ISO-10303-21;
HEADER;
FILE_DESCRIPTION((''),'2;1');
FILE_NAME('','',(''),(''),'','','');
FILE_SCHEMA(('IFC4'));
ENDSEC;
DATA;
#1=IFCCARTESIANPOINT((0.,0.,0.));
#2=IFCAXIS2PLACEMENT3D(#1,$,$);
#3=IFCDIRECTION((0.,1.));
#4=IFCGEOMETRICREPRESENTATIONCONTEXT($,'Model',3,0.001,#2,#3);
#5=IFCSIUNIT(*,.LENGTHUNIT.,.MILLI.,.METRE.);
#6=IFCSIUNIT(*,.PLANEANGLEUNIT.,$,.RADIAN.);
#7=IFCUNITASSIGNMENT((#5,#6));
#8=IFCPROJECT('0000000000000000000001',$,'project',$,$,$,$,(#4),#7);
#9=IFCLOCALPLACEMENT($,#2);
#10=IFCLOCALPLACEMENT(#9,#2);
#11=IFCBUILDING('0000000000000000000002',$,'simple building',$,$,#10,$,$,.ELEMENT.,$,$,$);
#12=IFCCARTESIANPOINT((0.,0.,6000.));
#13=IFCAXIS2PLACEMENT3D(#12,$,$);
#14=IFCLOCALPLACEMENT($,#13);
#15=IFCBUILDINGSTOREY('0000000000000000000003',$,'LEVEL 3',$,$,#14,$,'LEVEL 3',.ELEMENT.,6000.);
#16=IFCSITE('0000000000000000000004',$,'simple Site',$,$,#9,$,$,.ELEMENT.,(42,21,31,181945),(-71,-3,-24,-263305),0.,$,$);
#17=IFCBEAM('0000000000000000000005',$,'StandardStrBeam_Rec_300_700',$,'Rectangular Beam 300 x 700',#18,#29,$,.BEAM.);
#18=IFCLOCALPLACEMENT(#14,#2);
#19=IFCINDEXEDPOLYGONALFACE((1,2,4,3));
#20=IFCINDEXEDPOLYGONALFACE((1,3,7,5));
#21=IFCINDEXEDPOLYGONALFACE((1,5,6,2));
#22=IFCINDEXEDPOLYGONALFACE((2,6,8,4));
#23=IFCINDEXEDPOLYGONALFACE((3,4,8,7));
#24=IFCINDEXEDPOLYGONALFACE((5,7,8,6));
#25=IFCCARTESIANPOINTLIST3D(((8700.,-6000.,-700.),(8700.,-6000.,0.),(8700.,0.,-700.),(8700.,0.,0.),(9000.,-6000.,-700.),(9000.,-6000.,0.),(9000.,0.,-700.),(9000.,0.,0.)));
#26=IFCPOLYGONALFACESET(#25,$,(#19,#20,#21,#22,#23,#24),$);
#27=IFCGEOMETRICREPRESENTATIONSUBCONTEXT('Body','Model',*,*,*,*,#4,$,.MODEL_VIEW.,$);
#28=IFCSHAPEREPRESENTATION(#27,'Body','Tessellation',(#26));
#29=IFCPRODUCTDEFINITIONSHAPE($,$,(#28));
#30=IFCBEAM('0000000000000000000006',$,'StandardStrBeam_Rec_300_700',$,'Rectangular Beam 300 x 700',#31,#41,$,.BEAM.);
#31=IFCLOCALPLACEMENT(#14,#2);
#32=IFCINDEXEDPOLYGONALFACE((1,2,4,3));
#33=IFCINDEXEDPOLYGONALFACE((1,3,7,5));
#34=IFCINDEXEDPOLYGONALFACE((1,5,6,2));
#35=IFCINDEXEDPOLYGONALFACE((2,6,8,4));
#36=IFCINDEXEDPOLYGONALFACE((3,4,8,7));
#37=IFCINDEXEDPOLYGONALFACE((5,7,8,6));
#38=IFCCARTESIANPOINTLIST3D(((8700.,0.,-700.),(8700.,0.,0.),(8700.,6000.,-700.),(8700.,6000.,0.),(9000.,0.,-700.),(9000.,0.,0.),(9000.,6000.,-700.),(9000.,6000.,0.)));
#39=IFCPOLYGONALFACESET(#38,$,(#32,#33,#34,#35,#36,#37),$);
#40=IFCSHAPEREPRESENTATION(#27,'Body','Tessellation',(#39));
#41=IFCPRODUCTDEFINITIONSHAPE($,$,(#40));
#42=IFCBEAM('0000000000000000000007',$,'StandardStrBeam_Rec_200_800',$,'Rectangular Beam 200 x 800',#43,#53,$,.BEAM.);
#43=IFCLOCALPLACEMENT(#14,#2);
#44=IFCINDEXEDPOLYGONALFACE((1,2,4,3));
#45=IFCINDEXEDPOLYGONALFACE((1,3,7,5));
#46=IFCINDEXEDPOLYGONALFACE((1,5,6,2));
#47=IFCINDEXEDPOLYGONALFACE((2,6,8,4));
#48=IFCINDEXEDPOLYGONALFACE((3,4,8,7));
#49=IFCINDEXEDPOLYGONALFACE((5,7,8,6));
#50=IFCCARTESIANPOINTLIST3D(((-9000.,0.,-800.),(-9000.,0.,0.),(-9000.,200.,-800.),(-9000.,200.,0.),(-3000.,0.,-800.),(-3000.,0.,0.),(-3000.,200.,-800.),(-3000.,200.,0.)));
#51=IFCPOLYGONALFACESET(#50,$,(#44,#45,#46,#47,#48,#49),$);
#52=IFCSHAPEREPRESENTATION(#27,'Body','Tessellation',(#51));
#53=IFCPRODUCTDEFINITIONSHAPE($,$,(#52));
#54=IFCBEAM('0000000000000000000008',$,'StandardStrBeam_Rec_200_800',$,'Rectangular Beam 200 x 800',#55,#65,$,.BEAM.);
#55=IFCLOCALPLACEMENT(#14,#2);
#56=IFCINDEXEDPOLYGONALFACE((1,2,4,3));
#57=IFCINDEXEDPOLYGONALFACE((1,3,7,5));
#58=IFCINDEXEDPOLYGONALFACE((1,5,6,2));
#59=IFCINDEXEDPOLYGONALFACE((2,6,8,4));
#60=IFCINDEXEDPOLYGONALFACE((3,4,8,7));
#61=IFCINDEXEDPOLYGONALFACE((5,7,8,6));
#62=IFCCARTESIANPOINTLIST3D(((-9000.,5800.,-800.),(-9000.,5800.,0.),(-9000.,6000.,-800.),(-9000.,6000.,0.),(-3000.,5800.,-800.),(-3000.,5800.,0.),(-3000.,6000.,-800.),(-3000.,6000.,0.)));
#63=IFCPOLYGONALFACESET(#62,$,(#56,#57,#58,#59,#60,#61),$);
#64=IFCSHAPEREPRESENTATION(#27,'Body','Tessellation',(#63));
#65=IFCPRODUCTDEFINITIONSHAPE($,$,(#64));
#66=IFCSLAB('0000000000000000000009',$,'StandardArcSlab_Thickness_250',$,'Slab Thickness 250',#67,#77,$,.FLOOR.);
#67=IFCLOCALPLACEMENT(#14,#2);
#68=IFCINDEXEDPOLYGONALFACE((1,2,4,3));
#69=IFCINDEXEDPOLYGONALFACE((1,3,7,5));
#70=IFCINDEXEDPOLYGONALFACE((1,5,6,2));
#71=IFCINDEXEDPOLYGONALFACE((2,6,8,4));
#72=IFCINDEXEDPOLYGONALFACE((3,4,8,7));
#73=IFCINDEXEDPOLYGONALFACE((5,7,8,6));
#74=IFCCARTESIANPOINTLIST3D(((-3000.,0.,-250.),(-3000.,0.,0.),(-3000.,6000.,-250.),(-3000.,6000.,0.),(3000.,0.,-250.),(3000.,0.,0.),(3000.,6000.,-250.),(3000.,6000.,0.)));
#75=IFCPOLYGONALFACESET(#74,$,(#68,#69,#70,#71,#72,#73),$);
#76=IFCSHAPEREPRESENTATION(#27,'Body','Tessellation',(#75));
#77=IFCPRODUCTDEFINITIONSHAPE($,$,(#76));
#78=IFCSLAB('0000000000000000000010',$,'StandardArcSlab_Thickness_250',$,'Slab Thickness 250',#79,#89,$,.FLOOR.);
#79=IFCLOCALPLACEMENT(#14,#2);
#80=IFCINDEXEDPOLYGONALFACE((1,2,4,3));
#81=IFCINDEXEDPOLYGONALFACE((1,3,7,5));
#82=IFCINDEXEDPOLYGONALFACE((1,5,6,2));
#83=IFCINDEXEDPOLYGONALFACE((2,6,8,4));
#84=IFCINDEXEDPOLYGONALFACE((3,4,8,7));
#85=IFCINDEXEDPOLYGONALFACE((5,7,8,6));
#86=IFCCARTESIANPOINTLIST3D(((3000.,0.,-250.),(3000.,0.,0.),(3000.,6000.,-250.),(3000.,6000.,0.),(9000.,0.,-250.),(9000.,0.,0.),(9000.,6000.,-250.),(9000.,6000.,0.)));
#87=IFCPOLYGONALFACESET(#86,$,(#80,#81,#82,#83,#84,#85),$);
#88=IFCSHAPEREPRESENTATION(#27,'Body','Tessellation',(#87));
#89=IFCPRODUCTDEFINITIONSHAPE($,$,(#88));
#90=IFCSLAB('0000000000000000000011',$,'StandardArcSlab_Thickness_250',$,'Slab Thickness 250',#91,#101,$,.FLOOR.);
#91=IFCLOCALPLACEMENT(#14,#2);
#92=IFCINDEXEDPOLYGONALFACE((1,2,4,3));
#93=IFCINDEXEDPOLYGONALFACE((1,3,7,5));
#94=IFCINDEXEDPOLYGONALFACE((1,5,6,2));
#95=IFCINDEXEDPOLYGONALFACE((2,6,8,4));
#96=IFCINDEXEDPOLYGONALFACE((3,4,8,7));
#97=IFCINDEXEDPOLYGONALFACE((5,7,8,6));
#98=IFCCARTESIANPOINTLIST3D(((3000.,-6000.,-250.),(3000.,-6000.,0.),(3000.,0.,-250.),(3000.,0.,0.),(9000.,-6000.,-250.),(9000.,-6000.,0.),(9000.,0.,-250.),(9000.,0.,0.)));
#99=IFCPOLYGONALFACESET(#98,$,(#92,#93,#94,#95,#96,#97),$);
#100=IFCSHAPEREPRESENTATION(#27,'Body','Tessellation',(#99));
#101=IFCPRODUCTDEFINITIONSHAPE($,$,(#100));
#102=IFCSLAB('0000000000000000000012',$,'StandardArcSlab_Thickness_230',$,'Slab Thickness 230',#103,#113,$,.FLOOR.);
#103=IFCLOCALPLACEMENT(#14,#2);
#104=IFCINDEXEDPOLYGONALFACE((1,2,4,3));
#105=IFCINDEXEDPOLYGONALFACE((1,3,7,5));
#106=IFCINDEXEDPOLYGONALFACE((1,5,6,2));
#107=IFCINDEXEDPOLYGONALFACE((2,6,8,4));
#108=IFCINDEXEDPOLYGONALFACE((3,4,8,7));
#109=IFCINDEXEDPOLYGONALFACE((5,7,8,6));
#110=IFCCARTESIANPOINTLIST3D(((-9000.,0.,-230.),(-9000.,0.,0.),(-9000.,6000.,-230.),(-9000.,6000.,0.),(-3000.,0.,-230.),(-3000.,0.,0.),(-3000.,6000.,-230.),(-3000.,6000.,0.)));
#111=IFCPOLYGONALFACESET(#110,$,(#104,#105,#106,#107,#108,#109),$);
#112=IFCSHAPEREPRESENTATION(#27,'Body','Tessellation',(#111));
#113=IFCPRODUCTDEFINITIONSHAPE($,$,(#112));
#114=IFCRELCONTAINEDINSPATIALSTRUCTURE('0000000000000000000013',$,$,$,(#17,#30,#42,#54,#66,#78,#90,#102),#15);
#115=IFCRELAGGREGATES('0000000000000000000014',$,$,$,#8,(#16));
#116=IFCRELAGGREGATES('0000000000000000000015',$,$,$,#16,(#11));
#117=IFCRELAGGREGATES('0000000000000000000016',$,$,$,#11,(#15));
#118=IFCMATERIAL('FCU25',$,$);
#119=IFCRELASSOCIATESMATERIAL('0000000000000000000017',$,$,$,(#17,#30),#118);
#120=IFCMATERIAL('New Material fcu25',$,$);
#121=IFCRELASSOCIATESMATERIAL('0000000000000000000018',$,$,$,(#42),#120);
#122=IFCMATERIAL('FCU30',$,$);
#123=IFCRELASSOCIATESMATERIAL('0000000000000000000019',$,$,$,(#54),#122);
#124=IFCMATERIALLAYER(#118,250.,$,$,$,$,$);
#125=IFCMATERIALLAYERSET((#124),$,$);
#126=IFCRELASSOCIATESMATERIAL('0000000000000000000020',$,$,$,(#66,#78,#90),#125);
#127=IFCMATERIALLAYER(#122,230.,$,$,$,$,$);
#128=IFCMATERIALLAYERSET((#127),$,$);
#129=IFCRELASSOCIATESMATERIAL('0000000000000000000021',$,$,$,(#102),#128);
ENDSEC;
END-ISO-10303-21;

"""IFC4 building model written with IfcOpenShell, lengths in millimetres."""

from ifc_helpers import new_model, si_unit, direction, frame, origin, origin_with_axes, origin_2d_with_axis, place, context, subcontext, project, spatial, polyline, rectangle, outline, extrude, material, layer, layer_set, layer_usage, material_profile, profile_set, profile_usage, element, save


model = new_model("IFC4")

# Units and contexts
model_context = context("Model", 3, precision=0.001, world=origin(), true_north=direction((0.0, 1.0)))
body_context = subcontext(model_context, "Body", "Model", "MODEL_VIEW")
ifc_project = project(units=[si_unit("LENGTHUNIT", "METRE", prefix="MILLI"), si_unit("PLANEANGLEUNIT", "RADIAN")], contexts=[model_context])

# Site, building, storey
site_placement = place(None, origin())
site = spatial("IfcSite", under=ifc_project, at=site_placement, Name="simple Site", CompositionType="ELEMENT", RefLatitude=(42, 21, 31, 181945), RefLongitude=(-71, -3, -24, -263305), RefElevation=0.0)
building_placement = place(site_placement, origin())
building = spatial("IfcBuilding", under=site, at=building_placement, Name="simple building", CompositionType="ELEMENT")
storey_placement = place(None, frame((0.0, 0.0, 6000.0)))
storey = spatial("IfcBuildingStorey", under=building, at=storey_placement, Name="LEVEL 3", LongName="LEVEL 3", CompositionType="ELEMENT", Elevation=6000.0)

# Shared definitions
ifc_material_1 = material(Name="FCU30")

# Beams
ifc_material_2 = material(Name="FCU25")
ifc_material_profile_1 = material_profile(ifc_material_2, rectangle(XDim=300.0, YDim=700.0, at=origin_2d_with_axis()))
ifc_profile_set_1 = profile_set([ifc_material_profile_1])
ifc_profile_usage_1 = profile_usage(ifc_profile_set_1, cardinal=9)
for number, where, z_axis, x_axis, name in (
    (1, (8850.0, -6000.0, 5650.0), (0.0, 1.0, 0.0), (1.0, 0.0, 0.0), "StandardStrBeam_Rec_300_700"),
    (2, (8850.0, 0.0, 5650.0), (0.0, 1.0, 0.0), (1.0, 0.0, 0.0), "StandardStrBeam_Rec_300_700"),
):
    element("IfcBeam", number, at=place(None, frame(where, z_axis=z_axis, x_axis=x_axis)), inside=storey, material=ifc_profile_usage_1, Name=name, ObjectType="Rectangular Beam 300 x 700", PredefinedType="BEAM", context=body_context, shape_type="SweptSolid", body=[
        extrude(rectangle(XDim=300.0, YDim=700.0, at=origin_2d_with_axis()), origin_with_axes(), (0.0, 0.0, 1.0), 6000.0),
    ])
ifc_material_3 = material(Name="New Material fcu25")
ifc_material_profile_2 = material_profile(ifc_material_3, rectangle(XDim=200.0, YDim=800.0, at=origin_2d_with_axis()))
ifc_profile_set_2 = profile_set([ifc_material_profile_2])
ifc_profile_usage_2 = profile_usage(ifc_profile_set_2, cardinal=9)
beam_1_placement = place(None, frame((-9000.0, 100.0, 5600.0), z_axis=(1.0, 0.0, 0.0), x_axis=(0.0, -1.0, 0.0)))
element("IfcBeam", 3, at=beam_1_placement, inside=storey, material=ifc_profile_usage_2, Name="StandardStrBeam_Rec_200_800", ObjectType="Rectangular Beam 200 x 800", PredefinedType="BEAM", context=body_context, shape_type="SweptSolid", body=[
    extrude(rectangle(XDim=200.0, YDim=800.0, at=origin_2d_with_axis()), origin_with_axes(), (0.0, 0.0, 1.0), 6000.0),
])
ifc_material_profile_3 = material_profile(ifc_material_1, rectangle(XDim=200.0, YDim=800.0, at=origin_2d_with_axis()))
ifc_profile_set_3 = profile_set([ifc_material_profile_3])
ifc_profile_usage_3 = profile_usage(ifc_profile_set_3, cardinal=7)
beam_2_placement = place(None, frame((-9000.0, 5900.0, 5600.0), z_axis=(1.0, 0.0, 0.0), x_axis=(0.0, -1.0, 0.0)))
element("IfcBeam", 4, at=beam_2_placement, inside=storey, material=ifc_profile_usage_3, Name="StandardStrBeam_Rec_200_800", ObjectType="Rectangular Beam 200 x 800", PredefinedType="BEAM", context=body_context, shape_type="SweptSolid", body=[
    extrude(rectangle(XDim=200.0, YDim=800.0, at=origin_2d_with_axis()), origin_with_axes(), (0.0, 0.0, 1.0), 6000.0),
])

# Slabs
ifc_layer_1 = layer(ifc_material_2, 250.0)
ifc_layer_set_1 = layer_set([ifc_layer_1])
ifc_layer_usage_1 = layer_usage(ifc_layer_set_1, "AXIS3", "POSITIVE", -250.0)
for number, where, z_axis, x_axis, name in (
    (5, (-3000.0, 0.0, 5750.0), (0.0, 0.0, 1.0), (1.0, 0.0, 0.0), "StandardArcSlab_Thickness_250"),
    (6, (3000.0, 0.0, 5750.0), (0.0, 0.0, 1.0), (1.0, 0.0, 0.0), "StandardArcSlab_Thickness_250"),
    (7, (3000.0, -6000.0, 5750.0), (0.0, 0.0, 1.0), (1.0, 0.0, 0.0), "StandardArcSlab_Thickness_250"),
):
    element("IfcSlab", number, at=place(None, frame(where, z_axis=z_axis, x_axis=x_axis)), inside=storey, material=ifc_layer_usage_1, Name=name, ObjectType="Slab Thickness 250", PredefinedType="FLOOR", context=body_context, shape_type="SweptSolid", body=[
        extrude(outline(polyline([(0.0, 0.0), (6000.0, 0.0), (6000.0, 6000.0), (0.0, 6000.0), (0.0, 0.0)])), origin_with_axes(), (0.0, 0.0, 1.0), 250.0),
    ])
ifc_layer_2 = layer(ifc_material_1, 230.0)
ifc_layer_set_2 = layer_set([ifc_layer_2])
ifc_layer_usage_2 = layer_usage(ifc_layer_set_2, "AXIS3", "POSITIVE", -230.0)
slab_placement = place(None, frame((-9000.0, 6000.0, 5770.0), z_axis=(0.0, 0.0, 1.0), x_axis=(0.0, -1.0, 0.0)))
element("IfcSlab", 8, at=slab_placement, inside=storey, material=ifc_layer_usage_2, Name="StandardArcSlab_Thickness_230", ObjectType="Slab Thickness 230", PredefinedType="FLOOR", context=body_context, shape_type="SweptSolid", body=[
    extrude(outline(polyline([(0.0, 0.0), (6000.0, 0.0), (6000.0, 6000.0), (0.0, 6000.0), (0.0, 0.0), (0.0, 0.0)])), origin_with_axes(), (0.0, 0.0, 1.0), 230.0),
])

save(model, "model.ifc")
